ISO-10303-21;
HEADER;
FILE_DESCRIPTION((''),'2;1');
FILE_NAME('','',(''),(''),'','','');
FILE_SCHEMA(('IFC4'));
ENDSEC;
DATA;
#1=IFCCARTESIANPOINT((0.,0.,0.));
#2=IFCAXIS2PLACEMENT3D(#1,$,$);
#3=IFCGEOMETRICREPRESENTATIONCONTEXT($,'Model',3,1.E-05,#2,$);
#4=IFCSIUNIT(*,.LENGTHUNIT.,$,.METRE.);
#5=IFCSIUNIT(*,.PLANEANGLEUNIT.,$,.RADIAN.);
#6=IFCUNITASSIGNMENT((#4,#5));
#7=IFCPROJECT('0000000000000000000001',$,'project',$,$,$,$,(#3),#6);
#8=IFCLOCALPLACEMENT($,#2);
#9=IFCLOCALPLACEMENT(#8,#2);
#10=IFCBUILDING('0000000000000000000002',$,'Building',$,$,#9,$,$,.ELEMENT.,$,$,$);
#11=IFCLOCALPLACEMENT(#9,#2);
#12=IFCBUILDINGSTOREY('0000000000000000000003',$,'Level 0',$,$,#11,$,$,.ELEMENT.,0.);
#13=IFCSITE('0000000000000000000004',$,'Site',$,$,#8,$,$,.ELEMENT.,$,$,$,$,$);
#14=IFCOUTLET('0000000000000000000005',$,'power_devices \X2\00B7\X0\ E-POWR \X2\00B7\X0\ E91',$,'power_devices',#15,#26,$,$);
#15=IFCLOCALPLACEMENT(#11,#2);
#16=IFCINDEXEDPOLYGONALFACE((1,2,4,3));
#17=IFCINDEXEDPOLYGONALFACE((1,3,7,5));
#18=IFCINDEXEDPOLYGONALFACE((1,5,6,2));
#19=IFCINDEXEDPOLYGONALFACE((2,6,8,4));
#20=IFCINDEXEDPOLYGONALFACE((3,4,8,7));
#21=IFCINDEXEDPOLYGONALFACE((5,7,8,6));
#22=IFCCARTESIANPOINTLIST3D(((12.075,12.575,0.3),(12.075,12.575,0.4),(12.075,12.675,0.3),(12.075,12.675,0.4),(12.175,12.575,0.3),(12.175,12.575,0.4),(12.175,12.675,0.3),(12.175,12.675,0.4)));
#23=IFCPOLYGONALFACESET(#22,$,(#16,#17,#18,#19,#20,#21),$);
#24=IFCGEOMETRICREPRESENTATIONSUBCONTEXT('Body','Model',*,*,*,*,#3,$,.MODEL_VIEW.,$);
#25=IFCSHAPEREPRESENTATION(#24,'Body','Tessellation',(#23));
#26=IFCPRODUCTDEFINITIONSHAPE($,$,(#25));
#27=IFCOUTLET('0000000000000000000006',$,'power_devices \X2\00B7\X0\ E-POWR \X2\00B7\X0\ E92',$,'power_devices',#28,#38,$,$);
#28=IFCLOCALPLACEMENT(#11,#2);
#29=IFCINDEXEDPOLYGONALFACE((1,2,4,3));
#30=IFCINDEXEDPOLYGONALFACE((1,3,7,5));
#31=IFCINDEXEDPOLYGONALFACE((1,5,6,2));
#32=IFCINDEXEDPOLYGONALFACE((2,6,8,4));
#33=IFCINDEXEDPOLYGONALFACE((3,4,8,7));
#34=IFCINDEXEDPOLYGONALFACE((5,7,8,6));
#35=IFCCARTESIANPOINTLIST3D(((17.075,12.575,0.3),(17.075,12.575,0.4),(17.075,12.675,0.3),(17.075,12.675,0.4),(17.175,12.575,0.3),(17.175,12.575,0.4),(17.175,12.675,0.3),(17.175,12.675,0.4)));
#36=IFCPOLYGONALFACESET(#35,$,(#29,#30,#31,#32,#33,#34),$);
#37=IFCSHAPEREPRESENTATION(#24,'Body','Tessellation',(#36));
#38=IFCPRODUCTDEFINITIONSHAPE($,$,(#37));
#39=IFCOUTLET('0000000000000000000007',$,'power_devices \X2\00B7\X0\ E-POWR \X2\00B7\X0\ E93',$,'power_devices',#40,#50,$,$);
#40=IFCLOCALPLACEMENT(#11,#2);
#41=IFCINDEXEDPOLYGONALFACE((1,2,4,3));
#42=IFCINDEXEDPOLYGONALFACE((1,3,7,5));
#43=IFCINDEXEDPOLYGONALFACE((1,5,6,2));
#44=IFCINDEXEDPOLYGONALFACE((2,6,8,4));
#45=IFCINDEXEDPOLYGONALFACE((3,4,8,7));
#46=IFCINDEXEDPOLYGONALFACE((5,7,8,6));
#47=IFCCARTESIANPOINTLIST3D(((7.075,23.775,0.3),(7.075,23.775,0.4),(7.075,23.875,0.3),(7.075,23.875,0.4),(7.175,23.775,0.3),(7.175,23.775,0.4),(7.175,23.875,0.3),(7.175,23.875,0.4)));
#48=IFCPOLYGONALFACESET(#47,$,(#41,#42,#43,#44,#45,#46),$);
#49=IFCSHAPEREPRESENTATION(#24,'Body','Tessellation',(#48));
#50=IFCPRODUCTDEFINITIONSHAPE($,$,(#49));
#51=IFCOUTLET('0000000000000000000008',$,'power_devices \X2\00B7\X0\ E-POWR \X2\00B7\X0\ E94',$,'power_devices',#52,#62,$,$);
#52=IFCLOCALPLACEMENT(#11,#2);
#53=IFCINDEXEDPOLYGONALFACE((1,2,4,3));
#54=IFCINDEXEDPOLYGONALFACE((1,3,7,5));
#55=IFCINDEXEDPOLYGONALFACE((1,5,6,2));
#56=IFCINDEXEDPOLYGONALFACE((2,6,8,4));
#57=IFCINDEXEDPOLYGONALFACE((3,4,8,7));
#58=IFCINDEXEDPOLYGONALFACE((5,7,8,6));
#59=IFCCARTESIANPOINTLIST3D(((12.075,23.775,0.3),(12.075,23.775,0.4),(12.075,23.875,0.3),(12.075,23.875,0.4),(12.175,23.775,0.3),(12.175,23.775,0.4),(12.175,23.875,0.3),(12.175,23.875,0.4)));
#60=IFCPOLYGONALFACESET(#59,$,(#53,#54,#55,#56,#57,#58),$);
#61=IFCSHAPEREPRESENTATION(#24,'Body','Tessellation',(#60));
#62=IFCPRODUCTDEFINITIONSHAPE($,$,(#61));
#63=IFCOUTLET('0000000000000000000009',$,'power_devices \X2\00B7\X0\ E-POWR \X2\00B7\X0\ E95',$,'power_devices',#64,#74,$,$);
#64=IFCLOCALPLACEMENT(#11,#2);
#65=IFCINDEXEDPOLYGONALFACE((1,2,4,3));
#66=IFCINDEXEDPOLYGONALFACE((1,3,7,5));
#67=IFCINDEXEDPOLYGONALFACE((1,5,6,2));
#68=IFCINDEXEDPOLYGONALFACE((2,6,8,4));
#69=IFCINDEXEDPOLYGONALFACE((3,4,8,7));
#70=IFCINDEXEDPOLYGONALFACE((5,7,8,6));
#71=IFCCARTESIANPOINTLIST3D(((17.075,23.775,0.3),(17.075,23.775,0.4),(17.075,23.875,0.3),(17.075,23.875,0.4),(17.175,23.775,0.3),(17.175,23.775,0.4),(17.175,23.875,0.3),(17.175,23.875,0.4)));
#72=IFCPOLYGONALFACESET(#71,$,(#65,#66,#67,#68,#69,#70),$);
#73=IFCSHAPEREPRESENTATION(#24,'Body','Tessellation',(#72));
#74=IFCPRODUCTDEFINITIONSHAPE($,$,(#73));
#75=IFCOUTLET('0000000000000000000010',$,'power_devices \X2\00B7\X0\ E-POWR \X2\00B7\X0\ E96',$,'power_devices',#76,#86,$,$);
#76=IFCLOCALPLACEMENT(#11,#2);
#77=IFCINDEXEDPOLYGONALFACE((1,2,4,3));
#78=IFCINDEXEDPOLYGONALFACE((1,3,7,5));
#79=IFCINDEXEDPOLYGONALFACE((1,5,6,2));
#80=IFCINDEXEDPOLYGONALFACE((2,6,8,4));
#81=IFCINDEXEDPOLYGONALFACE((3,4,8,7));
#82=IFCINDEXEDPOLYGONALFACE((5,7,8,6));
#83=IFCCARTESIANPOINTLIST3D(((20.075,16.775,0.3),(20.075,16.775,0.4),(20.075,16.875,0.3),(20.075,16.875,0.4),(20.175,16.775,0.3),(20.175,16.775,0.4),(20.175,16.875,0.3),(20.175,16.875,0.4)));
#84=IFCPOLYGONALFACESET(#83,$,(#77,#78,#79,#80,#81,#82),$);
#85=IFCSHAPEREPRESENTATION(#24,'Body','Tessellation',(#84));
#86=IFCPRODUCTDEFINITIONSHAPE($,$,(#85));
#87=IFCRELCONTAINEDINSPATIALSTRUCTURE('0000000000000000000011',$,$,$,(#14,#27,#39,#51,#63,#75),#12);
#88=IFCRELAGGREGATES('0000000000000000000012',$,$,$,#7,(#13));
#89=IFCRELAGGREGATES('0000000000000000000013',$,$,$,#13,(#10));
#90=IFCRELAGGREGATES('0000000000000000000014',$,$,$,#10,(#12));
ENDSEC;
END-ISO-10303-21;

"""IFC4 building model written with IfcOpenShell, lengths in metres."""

from ifc_helpers import new_model, si_unit, frame, origin, place, context, subcontext, project, spatial, polyline, outline, extrude, element, save


model = new_model("IFC4")

# Units and contexts
model_context = context("Model", 3, precision=1e-05, world=origin())
body_context = subcontext(model_context, "Body", "Model", "MODEL_VIEW")
ifc_project = project(units=[si_unit("LENGTHUNIT", "METRE"), si_unit("PLANEANGLEUNIT", "RADIAN")], contexts=[model_context])

# Site, building, storey
site_placement = place(None, origin())
site = spatial("IfcSite", under=ifc_project, at=site_placement, Name="Site", CompositionType="ELEMENT")
building_placement = place(site_placement, origin())
building = spatial("IfcBuilding", under=site, at=building_placement, Name="Building", CompositionType="ELEMENT")
storey_placement = place(building_placement, origin())
storey = spatial("IfcBuildingStorey", under=building, at=storey_placement, Name="Level 0", CompositionType="ELEMENT", Elevation=0.0)

# Outlets
outlet_1_placement = place(storey_placement, frame((0.0, 0.0, 0.3)))
element("IfcOutlet", 1, at=outlet_1_placement, inside=storey, Name="power_devices · E-POWR · E91", ObjectType="power_devices", context=body_context, shape_type="SweptSolid", body=[
    extrude(outline(polyline([(12.075, 12.575), (12.175, 12.575), (12.175, 12.675), (12.075, 12.675), (12.075, 12.575)])), origin(), (0.0, 0.0, 1.0), 0.1),
])
outlet_2_placement = place(storey_placement, frame((0.0, 0.0, 0.3)))
element("IfcOutlet", 2, at=outlet_2_placement, inside=storey, Name="power_devices · E-POWR · E92", ObjectType="power_devices", context=body_context, shape_type="SweptSolid", body=[
    extrude(outline(polyline([(17.075, 12.575), (17.175, 12.575), (17.175, 12.675), (17.075, 12.675), (17.075, 12.575)])), origin(), (0.0, 0.0, 1.0), 0.1),
])
outlet_3_placement = place(storey_placement, frame((0.0, 0.0, 0.3)))
element("IfcOutlet", 3, at=outlet_3_placement, inside=storey, Name="power_devices · E-POWR · E93", ObjectType="power_devices", context=body_context, shape_type="SweptSolid", body=[
    extrude(outline(polyline([(7.075, 23.775), (7.175, 23.775), (7.175, 23.875), (7.075, 23.875), (7.075, 23.775)])), origin(), (0.0, 0.0, 1.0), 0.1),
])
outlet_4_placement = place(storey_placement, frame((0.0, 0.0, 0.3)))
element("IfcOutlet", 4, at=outlet_4_placement, inside=storey, Name="power_devices · E-POWR · E94", ObjectType="power_devices", context=body_context, shape_type="SweptSolid", body=[
    extrude(outline(polyline([(12.075, 23.775), (12.175, 23.775), (12.175, 23.875), (12.075, 23.875), (12.075, 23.775)])), origin(), (0.0, 0.0, 1.0), 0.1),
])
outlet_5_placement = place(storey_placement, frame((0.0, 0.0, 0.3)))
element("IfcOutlet", 5, at=outlet_5_placement, inside=storey, Name="power_devices · E-POWR · E95", ObjectType="power_devices", context=body_context, shape_type="SweptSolid", body=[
    extrude(outline(polyline([(17.075, 23.775), (17.175, 23.775), (17.175, 23.875), (17.075, 23.875), (17.075, 23.775)])), origin(), (0.0, 0.0, 1.0), 0.1),
])
outlet_6_placement = place(storey_placement, frame((0.0, 0.0, 0.3)))
element("IfcOutlet", 6, at=outlet_6_placement, inside=storey, Name="power_devices · E-POWR · E96", ObjectType="power_devices", context=body_context, shape_type="SweptSolid", body=[
    extrude(outline(polyline([(20.075, 16.775), (20.175, 16.775), (20.175, 16.875), (20.075, 16.875), (20.075, 16.775)])), origin(), (0.0, 0.0, 1.0), 0.1),
])

save(model, "model.ifc")
